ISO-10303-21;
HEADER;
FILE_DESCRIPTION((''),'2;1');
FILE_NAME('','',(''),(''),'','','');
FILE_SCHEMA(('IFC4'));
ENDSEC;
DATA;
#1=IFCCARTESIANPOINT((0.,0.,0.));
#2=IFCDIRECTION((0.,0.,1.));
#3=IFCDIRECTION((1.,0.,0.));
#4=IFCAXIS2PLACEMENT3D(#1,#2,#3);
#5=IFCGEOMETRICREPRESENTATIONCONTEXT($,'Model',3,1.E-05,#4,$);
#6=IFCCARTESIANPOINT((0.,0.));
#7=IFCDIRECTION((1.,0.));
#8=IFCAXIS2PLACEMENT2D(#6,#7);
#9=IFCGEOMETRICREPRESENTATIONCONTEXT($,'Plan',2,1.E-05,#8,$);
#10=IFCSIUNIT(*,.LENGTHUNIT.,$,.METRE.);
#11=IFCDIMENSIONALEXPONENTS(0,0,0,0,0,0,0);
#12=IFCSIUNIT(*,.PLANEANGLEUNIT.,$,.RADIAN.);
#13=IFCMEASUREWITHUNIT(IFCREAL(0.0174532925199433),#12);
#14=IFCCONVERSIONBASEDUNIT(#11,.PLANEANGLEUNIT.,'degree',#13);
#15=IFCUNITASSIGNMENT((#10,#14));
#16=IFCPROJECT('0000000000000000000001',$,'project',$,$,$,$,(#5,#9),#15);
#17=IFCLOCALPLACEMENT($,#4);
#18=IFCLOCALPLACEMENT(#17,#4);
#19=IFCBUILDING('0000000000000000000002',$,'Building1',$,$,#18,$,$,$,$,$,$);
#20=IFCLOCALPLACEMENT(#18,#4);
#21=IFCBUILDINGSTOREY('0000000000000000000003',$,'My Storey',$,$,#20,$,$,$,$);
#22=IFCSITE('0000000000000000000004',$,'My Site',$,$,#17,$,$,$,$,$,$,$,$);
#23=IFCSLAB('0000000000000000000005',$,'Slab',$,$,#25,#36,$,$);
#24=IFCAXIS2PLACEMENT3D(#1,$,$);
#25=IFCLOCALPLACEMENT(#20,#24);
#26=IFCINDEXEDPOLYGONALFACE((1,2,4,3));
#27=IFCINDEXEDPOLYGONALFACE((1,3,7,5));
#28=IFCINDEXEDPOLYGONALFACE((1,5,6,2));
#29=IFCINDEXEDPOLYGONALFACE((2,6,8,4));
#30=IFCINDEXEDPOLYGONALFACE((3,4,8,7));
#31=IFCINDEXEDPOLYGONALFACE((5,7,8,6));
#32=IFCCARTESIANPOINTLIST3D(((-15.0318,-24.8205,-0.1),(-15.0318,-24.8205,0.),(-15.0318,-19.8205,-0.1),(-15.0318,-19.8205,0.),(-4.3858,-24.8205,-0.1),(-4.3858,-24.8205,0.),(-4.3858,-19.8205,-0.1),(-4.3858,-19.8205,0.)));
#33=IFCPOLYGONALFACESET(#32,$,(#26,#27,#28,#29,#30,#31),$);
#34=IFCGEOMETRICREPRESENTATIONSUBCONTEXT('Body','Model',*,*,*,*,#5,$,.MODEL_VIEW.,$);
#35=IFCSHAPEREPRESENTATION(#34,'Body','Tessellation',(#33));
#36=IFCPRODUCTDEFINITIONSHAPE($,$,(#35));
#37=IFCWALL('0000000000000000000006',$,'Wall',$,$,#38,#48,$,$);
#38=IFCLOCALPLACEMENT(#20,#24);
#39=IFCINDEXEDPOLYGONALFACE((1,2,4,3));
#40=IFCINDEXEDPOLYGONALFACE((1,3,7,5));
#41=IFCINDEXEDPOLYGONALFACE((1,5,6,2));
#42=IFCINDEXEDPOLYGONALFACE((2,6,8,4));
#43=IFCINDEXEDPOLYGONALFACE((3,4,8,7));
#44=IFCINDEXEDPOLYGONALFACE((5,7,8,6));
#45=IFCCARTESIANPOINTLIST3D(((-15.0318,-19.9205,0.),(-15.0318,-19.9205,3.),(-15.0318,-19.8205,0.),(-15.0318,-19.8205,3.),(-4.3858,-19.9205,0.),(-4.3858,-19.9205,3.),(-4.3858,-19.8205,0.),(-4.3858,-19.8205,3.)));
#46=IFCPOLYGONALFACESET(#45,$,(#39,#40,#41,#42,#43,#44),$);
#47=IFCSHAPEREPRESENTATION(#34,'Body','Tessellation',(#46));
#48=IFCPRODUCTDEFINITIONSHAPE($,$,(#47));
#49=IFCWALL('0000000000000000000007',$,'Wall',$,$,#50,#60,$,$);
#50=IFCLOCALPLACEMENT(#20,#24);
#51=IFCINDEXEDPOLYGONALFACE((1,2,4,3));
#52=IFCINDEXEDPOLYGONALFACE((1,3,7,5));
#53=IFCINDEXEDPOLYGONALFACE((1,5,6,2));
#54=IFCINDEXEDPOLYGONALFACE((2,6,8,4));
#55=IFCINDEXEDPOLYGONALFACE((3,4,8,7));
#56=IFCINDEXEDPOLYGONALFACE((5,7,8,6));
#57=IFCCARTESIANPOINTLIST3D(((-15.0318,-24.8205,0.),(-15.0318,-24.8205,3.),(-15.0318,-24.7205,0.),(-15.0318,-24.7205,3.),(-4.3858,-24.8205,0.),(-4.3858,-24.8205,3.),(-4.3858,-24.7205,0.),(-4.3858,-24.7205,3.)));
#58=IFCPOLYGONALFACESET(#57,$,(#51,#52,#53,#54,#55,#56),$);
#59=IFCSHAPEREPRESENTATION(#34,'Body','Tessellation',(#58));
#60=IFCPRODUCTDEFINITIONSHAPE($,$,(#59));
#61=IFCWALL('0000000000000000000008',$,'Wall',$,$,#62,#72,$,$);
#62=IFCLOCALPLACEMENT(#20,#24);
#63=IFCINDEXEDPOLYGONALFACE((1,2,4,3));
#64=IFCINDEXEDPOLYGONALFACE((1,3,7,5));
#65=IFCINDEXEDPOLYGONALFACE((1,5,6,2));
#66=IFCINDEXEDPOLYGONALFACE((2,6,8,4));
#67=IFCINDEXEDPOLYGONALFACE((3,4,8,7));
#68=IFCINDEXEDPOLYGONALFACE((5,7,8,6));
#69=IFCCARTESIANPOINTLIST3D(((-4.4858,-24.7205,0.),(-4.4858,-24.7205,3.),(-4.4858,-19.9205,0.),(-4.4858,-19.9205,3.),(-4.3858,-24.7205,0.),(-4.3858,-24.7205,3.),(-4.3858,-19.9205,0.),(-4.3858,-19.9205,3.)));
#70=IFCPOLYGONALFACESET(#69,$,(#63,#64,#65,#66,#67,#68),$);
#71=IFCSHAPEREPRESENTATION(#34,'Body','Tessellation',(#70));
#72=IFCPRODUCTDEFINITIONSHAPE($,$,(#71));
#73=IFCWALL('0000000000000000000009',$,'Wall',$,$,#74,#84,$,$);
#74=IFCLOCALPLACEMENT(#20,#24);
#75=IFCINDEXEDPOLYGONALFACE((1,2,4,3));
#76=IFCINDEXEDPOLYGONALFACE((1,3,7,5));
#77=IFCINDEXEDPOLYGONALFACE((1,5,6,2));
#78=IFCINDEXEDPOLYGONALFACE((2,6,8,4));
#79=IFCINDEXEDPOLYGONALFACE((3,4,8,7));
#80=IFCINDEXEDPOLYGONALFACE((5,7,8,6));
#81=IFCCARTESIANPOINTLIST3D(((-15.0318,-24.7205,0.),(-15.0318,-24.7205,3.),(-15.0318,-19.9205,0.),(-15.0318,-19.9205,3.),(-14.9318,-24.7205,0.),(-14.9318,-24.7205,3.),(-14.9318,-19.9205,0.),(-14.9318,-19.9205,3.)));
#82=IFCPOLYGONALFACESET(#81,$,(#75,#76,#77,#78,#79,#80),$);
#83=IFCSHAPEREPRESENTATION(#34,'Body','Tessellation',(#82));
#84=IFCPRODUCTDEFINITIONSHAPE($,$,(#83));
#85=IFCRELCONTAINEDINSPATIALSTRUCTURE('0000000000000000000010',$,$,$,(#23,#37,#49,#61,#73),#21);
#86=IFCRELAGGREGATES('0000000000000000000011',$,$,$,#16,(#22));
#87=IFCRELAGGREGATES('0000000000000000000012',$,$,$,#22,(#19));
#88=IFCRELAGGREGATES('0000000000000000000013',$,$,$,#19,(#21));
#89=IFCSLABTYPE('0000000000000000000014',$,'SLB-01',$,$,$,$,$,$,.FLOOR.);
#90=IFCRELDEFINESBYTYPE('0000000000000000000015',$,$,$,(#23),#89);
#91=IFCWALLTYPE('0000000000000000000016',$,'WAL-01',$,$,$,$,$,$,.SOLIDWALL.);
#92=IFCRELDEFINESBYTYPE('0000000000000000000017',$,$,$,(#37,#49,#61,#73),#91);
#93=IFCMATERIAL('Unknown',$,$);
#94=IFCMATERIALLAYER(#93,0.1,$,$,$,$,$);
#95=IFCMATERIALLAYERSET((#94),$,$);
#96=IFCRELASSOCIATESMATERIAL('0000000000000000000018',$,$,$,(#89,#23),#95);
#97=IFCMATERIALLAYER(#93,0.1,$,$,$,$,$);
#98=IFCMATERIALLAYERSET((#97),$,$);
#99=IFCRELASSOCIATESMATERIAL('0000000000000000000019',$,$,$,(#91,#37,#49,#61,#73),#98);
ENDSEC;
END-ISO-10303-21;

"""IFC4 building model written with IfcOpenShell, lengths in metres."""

from ifc_helpers import new_model, entity, si_unit, converted_unit, frame, origin_with_axes, origin_2d_with_axis, place, context, subcontext, project, spatial, line, indexed_curve, outline, extrude, material, layer, layer_set, layer_usage, type_object, element, save


model = new_model("IFC4")

# Units and contexts
model_context = context("Model", 3, precision=1e-05, world=origin_with_axes())
plan_context = context("Plan", 2, precision=1e-05, world=origin_2d_with_axis())
body_context = subcontext(model_context, "Body", "Model", "MODEL_VIEW")
ifc_project = project(units=[si_unit("LENGTHUNIT", "METRE"), converted_unit("PLANEANGLEUNIT", "degree", entity("IfcReal", 0.0174532925199433), si_unit("PLANEANGLEUNIT", "RADIAN"), dimensions=[0, 0, 0, 0, 0, 0, 0])], contexts=[model_context, plan_context])

# Site, building, storey
site_placement = place(None, origin_with_axes())
site = spatial("IfcSite", under=ifc_project, at=site_placement, Name="My Site")
building_placement = place(site_placement, origin_with_axes())
building = spatial("IfcBuilding", under=site, at=building_placement, Name="Building1")
storey_placement = place(building_placement, origin_with_axes())
storey = spatial("IfcBuildingStorey", under=building, at=storey_placement, Name="My Storey")

# Slab
ifc_material = material(Name="Unknown")
ifc_layer_1 = layer(ifc_material, 0.1)
ifc_layer_set_1 = layer_set([ifc_layer_1])
ifc_layer_usage_1 = layer_usage(ifc_layer_set_1, "AXIS3", "POSITIVE", 0.0)
slab_type = type_object("IfcSlabType", Name="SLB-01", PredefinedType="FLOOR", material=ifc_layer_set_1)
slab_placement = place(storey_placement, frame((-15.0318, -24.8205, -0.1), z_axis=(0.0, 0.0, 1.0), x_axis=(1.0, 0.0, 0.0)))
element("IfcSlab", 1, at=slab_placement, inside=storey, type_object=slab_type, material=ifc_layer_usage_1, Name="Slab", context=body_context, shape_type="SweptSolid", body=[
    extrude(outline(indexed_curve([(0.0, 0.0), (10.646, 0.0), (10.646, 5.0), (0.0, 5.0)], segments=[line(3, 2), line(2, 1), line(1, 4), line(4, 3)], self_intersect=False)), None, (0.0, 0.0, 1.0), 0.1),
])

# Walls
ifc_layer_2 = layer(ifc_material, 0.1)
ifc_layer_set_2 = layer_set([ifc_layer_2])
ifc_layer_usage_2 = layer_usage(ifc_layer_set_2, "AXIS2", "POSITIVE", 0.0)
wall_type = type_object("IfcWallType", Name="WAL-01", PredefinedType="SOLIDWALL", material=ifc_layer_set_2)
wall_1_placement = place(storey_placement, frame((-4.3858, -19.8205, 0.0), z_axis=(0.0, 0.0, 1.0), x_axis=(-1.0, 0.0, 0.0)))
element("IfcWall", 2, at=wall_1_placement, inside=storey, type_object=wall_type, material=ifc_layer_usage_2, Name="Wall", context=body_context, shape_type="SweptSolid", body=[
    extrude(outline(indexed_curve([(0.0, 0.0), (0.0, 0.1), (10.646, 0.1), (10.646, 0.0), (0.0, 0.0)], self_intersect=False)), origin_with_axes(), (0.0, 0.0, 1.0), 3.0),
])
ifc_layer_usage_3 = layer_usage(ifc_layer_set_2, "AXIS2", "POSITIVE", 0.0)
wall_2_placement = place(storey_placement, frame((-4.3858, -24.7205, 0.0), z_axis=(0.0, 0.0, 1.0), x_axis=(-1.0, 0.0, 0.0)))
element("IfcWall", 3, at=wall_2_placement, inside=storey, type_object=wall_type, material=ifc_layer_usage_3, Name="Wall", context=body_context, shape_type="SweptSolid", body=[
    extrude(outline(indexed_curve([(0.0, 0.0), (0.0, 0.1), (10.646, 0.1), (10.646, 0.0), (0.0, 0.0)], self_intersect=False)), origin_with_axes(), (0.0, 0.0, 1.0), 3.0),
])
ifc_layer_usage_4 = layer_usage(ifc_layer_set_2, "AXIS2", "POSITIVE", 0.0)
wall_3_placement = place(storey_placement, frame((-4.3858, -24.7205, 0.0), z_axis=(0.0, 0.0, 1.0), x_axis=(0.0, 1.0, 0.0)))
element("IfcWall", 4, at=wall_3_placement, inside=storey, type_object=wall_type, material=ifc_layer_usage_4, Name="Wall", context=body_context, shape_type="SweptSolid", body=[
    extrude(outline(indexed_curve([(0.0, 0.0), (0.0, 0.1), (4.8, 0.1), (4.8, 0.0), (0.0, 0.0)], self_intersect=False)), origin_with_axes(), (0.0, 0.0, 1.0), 3.0),
])
ifc_layer_usage_5 = layer_usage(ifc_layer_set_2, "AXIS2", "POSITIVE", 0.0)
wall_4_placement = place(storey_placement, frame((-14.9318, -24.7205, 0.0), z_axis=(0.0, 0.0, 1.0), x_axis=(0.0, 1.0, 0.0)))
element("IfcWall", 5, at=wall_4_placement, inside=storey, type_object=wall_type, material=ifc_layer_usage_5, Name="Wall", context=body_context, shape_type="SweptSolid", body=[
    extrude(outline(indexed_curve([(0.0, 0.0), (0.0, 0.1), (4.8, 0.1), (4.8, 0.0), (0.0, 0.0)], self_intersect=False)), origin_with_axes(), (0.0, 0.0, 1.0), 3.0),
])

save(model, "model.ifc")
